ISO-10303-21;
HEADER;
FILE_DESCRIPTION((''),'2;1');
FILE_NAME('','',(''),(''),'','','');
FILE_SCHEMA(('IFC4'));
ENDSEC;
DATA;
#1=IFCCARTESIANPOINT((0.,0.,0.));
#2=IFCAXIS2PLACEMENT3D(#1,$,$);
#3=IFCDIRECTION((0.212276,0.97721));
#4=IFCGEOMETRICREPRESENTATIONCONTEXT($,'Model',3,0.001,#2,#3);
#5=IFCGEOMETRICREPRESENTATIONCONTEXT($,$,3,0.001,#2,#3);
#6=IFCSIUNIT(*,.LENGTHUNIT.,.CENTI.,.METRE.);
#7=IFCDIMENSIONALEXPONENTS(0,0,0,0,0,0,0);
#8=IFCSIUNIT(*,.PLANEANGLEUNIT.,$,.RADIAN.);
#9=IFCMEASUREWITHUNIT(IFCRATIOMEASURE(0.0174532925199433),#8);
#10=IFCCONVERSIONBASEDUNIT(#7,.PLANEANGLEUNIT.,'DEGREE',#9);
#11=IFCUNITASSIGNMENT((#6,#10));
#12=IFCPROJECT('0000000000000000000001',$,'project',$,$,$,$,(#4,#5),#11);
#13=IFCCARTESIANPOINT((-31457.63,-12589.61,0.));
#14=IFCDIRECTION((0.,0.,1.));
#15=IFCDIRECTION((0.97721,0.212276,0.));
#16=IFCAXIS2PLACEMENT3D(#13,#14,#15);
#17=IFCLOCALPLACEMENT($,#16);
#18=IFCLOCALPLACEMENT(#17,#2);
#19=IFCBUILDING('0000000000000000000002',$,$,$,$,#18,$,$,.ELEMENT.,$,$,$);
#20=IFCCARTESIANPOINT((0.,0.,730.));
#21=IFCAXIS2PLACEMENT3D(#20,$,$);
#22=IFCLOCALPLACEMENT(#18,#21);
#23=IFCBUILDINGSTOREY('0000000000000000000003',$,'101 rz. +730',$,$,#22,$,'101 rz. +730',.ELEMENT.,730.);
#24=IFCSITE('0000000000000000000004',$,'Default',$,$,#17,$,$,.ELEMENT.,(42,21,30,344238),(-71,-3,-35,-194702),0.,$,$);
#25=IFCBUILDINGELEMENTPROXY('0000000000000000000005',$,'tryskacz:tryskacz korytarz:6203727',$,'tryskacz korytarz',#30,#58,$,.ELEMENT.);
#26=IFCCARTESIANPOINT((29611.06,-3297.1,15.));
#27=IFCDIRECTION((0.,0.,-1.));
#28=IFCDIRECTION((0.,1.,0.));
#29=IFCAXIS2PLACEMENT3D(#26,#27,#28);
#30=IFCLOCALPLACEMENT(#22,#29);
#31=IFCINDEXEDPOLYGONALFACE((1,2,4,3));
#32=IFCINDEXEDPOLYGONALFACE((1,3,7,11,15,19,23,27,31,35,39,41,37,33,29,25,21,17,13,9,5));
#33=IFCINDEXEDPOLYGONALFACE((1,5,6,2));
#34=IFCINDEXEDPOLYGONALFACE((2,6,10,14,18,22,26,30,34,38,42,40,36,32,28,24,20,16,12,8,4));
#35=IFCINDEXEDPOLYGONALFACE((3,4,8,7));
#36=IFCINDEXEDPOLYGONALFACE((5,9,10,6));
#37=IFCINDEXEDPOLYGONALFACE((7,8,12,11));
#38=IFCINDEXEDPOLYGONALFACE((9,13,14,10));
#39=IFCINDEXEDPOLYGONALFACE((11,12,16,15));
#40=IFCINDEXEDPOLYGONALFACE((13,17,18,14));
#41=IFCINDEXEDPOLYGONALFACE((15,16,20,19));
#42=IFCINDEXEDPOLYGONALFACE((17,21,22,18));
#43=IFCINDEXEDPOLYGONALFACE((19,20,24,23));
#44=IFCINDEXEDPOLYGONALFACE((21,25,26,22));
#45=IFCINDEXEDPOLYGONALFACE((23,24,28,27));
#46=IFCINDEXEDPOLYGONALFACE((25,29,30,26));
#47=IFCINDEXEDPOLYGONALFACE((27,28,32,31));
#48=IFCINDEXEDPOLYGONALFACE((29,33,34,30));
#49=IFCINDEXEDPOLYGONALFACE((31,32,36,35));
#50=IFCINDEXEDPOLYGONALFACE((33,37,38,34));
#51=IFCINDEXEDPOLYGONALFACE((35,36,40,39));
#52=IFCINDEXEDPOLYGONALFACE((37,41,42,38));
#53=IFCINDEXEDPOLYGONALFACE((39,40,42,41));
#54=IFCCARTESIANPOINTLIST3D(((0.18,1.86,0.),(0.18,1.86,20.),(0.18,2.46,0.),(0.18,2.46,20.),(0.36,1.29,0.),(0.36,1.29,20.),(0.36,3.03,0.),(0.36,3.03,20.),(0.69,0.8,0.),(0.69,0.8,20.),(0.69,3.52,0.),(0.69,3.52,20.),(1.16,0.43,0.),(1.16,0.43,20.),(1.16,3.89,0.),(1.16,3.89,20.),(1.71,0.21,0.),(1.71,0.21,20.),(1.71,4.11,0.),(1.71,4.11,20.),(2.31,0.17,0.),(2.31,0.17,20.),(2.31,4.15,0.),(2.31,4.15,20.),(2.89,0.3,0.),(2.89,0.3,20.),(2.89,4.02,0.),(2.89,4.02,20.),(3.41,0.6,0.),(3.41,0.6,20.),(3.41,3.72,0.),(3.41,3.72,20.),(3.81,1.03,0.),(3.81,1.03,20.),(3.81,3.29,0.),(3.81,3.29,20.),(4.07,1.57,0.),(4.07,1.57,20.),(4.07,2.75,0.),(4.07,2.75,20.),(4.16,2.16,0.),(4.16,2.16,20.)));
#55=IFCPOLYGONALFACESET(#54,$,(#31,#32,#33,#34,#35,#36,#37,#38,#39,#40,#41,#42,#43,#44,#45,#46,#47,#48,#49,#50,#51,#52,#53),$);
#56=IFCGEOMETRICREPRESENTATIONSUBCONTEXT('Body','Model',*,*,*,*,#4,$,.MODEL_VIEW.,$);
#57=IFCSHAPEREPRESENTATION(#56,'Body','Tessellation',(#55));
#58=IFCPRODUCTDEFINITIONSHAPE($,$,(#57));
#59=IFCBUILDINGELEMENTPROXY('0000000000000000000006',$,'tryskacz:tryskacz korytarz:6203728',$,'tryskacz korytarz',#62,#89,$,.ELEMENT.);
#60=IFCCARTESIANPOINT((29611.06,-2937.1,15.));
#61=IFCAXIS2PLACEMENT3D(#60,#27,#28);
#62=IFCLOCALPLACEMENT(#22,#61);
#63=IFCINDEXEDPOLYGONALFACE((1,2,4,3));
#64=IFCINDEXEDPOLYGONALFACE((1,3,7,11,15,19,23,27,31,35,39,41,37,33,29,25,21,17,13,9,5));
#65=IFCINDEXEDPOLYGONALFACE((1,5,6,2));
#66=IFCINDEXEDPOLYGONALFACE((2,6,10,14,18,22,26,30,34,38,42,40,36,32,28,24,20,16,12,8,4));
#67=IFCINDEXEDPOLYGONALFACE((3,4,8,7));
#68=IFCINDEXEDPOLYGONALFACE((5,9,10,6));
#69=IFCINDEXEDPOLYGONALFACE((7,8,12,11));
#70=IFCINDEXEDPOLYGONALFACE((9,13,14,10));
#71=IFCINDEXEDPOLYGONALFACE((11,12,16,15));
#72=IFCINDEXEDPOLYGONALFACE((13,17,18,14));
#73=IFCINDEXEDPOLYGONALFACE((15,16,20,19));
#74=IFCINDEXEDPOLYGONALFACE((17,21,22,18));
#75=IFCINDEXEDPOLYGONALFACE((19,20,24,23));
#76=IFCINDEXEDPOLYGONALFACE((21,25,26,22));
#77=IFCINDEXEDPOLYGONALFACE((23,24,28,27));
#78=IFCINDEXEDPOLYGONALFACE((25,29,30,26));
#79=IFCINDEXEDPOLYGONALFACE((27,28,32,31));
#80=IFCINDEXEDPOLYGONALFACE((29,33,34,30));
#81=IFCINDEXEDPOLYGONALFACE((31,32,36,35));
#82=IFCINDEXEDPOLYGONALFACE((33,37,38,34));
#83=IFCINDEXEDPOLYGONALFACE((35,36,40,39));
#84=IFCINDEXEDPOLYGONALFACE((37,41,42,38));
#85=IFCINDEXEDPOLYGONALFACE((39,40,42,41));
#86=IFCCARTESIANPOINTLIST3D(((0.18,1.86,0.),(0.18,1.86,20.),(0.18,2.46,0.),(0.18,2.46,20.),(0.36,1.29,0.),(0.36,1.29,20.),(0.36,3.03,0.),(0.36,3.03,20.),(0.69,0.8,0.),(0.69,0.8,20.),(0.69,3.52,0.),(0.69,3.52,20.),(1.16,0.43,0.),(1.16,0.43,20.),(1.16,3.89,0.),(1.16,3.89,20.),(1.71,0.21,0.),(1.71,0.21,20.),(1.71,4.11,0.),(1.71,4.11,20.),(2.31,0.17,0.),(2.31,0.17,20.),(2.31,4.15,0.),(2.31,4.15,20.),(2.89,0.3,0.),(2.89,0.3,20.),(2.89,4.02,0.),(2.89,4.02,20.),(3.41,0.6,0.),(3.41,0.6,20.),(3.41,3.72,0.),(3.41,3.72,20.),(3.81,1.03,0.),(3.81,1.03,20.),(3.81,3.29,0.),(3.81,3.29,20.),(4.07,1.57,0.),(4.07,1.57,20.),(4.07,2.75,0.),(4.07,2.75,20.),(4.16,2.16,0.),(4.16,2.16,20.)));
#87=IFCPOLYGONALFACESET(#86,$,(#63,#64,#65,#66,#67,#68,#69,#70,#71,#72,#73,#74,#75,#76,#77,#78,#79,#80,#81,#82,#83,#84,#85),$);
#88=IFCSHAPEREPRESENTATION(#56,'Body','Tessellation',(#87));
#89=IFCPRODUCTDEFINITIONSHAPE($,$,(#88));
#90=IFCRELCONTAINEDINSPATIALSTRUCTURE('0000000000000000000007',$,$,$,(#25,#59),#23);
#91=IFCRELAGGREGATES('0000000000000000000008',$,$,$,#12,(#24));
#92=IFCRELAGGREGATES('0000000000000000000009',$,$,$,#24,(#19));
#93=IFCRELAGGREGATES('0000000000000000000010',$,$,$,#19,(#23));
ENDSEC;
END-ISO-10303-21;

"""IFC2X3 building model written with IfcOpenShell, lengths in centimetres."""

from ifc_helpers import new_model, entity, si_unit, converted_unit, direction, frame, frame_2d, origin, place, context, subcontext, project, spatial, circle, extrude, source, transform, mapped, element, save


model = new_model("IFC2X3")

# Units and contexts
model_context = context("Model", 3, precision=0.001, world=origin(), true_north=direction((0.212276, 0.97721)))
context_of_model = context(None, 3, precision=0.001, world=origin(), true_north=direction((0.212276, 0.97721)))
body_context = subcontext(model_context, "Body", "Model", "MODEL_VIEW")
ifc_project = project(units=[si_unit("LENGTHUNIT", "METRE", prefix="CENTI"), converted_unit("PLANEANGLEUNIT", "DEGREE", entity("IfcRatioMeasure", 0.0174532925199433), si_unit("PLANEANGLEUNIT", "RADIAN"), dimensions=[0, 0, 0, 0, 0, 0, 0])], contexts=[model_context, context_of_model])

# Site, building, storey
site_placement = place(None, frame((-31457.63, -12589.61, 0.0), z_axis=(0.0, 0.0, 1.0), x_axis=(0.97721, 0.212276, 0.0)))
site = spatial("IfcSite", under=ifc_project, at=site_placement, Name="Default", CompositionType="ELEMENT", RefLatitude=(42, 21, 30, 344238), RefLongitude=(-71, -3, -35, -194702), RefElevation=0.0)
building_placement = place(site_placement, origin())
building = spatial("IfcBuilding", under=site, at=building_placement, CompositionType="ELEMENT")
storey_placement = place(building_placement, frame((0.0, 0.0, 730.0)))
storey = spatial("IfcBuildingStorey", under=building, at=storey_placement, Name="101 rz. +730", LongName="101 rz. +730", CompositionType="ELEMENT", Elevation=730.0)

# Building element proxies
shared_shape_1 = source(origin(), body_context, "Body", "SweptSolid", [
    extrude(circle(Radius=2.0, at=frame_2d((0.0, 0.0), x_axis=(1.0, 0.0))), frame((2.16, 2.16, 0.0)), (0.0, 0.0, 1.0), 20.0),
])
for number, where, z_axis, x_axis, name in (
    (1, (29611.06, -3297.1, 15.0), (0.0, 0.0, -1.0), (0.0, 1.0, 0.0), "tryskacz:tryskacz korytarz:6203727"),
    (2, (29611.06, -2937.1, 15.0), (0.0, 0.0, -1.0), (0.0, 1.0, 0.0), "tryskacz:tryskacz korytarz:6203728"),
):
    element("IfcBuildingElementProxy", number, at=place(storey_placement, frame(where, z_axis=z_axis, x_axis=x_axis)), inside=storey, Name=name, ObjectType="tryskacz korytarz", CompositionType="ELEMENT", context=body_context, shape_type="MappedRepresentation", body=[
        mapped(shared_shape_1, transform((0.0, 0.0, 0.0), scale=1.0)),
    ])

save(model, "model.ifc")
